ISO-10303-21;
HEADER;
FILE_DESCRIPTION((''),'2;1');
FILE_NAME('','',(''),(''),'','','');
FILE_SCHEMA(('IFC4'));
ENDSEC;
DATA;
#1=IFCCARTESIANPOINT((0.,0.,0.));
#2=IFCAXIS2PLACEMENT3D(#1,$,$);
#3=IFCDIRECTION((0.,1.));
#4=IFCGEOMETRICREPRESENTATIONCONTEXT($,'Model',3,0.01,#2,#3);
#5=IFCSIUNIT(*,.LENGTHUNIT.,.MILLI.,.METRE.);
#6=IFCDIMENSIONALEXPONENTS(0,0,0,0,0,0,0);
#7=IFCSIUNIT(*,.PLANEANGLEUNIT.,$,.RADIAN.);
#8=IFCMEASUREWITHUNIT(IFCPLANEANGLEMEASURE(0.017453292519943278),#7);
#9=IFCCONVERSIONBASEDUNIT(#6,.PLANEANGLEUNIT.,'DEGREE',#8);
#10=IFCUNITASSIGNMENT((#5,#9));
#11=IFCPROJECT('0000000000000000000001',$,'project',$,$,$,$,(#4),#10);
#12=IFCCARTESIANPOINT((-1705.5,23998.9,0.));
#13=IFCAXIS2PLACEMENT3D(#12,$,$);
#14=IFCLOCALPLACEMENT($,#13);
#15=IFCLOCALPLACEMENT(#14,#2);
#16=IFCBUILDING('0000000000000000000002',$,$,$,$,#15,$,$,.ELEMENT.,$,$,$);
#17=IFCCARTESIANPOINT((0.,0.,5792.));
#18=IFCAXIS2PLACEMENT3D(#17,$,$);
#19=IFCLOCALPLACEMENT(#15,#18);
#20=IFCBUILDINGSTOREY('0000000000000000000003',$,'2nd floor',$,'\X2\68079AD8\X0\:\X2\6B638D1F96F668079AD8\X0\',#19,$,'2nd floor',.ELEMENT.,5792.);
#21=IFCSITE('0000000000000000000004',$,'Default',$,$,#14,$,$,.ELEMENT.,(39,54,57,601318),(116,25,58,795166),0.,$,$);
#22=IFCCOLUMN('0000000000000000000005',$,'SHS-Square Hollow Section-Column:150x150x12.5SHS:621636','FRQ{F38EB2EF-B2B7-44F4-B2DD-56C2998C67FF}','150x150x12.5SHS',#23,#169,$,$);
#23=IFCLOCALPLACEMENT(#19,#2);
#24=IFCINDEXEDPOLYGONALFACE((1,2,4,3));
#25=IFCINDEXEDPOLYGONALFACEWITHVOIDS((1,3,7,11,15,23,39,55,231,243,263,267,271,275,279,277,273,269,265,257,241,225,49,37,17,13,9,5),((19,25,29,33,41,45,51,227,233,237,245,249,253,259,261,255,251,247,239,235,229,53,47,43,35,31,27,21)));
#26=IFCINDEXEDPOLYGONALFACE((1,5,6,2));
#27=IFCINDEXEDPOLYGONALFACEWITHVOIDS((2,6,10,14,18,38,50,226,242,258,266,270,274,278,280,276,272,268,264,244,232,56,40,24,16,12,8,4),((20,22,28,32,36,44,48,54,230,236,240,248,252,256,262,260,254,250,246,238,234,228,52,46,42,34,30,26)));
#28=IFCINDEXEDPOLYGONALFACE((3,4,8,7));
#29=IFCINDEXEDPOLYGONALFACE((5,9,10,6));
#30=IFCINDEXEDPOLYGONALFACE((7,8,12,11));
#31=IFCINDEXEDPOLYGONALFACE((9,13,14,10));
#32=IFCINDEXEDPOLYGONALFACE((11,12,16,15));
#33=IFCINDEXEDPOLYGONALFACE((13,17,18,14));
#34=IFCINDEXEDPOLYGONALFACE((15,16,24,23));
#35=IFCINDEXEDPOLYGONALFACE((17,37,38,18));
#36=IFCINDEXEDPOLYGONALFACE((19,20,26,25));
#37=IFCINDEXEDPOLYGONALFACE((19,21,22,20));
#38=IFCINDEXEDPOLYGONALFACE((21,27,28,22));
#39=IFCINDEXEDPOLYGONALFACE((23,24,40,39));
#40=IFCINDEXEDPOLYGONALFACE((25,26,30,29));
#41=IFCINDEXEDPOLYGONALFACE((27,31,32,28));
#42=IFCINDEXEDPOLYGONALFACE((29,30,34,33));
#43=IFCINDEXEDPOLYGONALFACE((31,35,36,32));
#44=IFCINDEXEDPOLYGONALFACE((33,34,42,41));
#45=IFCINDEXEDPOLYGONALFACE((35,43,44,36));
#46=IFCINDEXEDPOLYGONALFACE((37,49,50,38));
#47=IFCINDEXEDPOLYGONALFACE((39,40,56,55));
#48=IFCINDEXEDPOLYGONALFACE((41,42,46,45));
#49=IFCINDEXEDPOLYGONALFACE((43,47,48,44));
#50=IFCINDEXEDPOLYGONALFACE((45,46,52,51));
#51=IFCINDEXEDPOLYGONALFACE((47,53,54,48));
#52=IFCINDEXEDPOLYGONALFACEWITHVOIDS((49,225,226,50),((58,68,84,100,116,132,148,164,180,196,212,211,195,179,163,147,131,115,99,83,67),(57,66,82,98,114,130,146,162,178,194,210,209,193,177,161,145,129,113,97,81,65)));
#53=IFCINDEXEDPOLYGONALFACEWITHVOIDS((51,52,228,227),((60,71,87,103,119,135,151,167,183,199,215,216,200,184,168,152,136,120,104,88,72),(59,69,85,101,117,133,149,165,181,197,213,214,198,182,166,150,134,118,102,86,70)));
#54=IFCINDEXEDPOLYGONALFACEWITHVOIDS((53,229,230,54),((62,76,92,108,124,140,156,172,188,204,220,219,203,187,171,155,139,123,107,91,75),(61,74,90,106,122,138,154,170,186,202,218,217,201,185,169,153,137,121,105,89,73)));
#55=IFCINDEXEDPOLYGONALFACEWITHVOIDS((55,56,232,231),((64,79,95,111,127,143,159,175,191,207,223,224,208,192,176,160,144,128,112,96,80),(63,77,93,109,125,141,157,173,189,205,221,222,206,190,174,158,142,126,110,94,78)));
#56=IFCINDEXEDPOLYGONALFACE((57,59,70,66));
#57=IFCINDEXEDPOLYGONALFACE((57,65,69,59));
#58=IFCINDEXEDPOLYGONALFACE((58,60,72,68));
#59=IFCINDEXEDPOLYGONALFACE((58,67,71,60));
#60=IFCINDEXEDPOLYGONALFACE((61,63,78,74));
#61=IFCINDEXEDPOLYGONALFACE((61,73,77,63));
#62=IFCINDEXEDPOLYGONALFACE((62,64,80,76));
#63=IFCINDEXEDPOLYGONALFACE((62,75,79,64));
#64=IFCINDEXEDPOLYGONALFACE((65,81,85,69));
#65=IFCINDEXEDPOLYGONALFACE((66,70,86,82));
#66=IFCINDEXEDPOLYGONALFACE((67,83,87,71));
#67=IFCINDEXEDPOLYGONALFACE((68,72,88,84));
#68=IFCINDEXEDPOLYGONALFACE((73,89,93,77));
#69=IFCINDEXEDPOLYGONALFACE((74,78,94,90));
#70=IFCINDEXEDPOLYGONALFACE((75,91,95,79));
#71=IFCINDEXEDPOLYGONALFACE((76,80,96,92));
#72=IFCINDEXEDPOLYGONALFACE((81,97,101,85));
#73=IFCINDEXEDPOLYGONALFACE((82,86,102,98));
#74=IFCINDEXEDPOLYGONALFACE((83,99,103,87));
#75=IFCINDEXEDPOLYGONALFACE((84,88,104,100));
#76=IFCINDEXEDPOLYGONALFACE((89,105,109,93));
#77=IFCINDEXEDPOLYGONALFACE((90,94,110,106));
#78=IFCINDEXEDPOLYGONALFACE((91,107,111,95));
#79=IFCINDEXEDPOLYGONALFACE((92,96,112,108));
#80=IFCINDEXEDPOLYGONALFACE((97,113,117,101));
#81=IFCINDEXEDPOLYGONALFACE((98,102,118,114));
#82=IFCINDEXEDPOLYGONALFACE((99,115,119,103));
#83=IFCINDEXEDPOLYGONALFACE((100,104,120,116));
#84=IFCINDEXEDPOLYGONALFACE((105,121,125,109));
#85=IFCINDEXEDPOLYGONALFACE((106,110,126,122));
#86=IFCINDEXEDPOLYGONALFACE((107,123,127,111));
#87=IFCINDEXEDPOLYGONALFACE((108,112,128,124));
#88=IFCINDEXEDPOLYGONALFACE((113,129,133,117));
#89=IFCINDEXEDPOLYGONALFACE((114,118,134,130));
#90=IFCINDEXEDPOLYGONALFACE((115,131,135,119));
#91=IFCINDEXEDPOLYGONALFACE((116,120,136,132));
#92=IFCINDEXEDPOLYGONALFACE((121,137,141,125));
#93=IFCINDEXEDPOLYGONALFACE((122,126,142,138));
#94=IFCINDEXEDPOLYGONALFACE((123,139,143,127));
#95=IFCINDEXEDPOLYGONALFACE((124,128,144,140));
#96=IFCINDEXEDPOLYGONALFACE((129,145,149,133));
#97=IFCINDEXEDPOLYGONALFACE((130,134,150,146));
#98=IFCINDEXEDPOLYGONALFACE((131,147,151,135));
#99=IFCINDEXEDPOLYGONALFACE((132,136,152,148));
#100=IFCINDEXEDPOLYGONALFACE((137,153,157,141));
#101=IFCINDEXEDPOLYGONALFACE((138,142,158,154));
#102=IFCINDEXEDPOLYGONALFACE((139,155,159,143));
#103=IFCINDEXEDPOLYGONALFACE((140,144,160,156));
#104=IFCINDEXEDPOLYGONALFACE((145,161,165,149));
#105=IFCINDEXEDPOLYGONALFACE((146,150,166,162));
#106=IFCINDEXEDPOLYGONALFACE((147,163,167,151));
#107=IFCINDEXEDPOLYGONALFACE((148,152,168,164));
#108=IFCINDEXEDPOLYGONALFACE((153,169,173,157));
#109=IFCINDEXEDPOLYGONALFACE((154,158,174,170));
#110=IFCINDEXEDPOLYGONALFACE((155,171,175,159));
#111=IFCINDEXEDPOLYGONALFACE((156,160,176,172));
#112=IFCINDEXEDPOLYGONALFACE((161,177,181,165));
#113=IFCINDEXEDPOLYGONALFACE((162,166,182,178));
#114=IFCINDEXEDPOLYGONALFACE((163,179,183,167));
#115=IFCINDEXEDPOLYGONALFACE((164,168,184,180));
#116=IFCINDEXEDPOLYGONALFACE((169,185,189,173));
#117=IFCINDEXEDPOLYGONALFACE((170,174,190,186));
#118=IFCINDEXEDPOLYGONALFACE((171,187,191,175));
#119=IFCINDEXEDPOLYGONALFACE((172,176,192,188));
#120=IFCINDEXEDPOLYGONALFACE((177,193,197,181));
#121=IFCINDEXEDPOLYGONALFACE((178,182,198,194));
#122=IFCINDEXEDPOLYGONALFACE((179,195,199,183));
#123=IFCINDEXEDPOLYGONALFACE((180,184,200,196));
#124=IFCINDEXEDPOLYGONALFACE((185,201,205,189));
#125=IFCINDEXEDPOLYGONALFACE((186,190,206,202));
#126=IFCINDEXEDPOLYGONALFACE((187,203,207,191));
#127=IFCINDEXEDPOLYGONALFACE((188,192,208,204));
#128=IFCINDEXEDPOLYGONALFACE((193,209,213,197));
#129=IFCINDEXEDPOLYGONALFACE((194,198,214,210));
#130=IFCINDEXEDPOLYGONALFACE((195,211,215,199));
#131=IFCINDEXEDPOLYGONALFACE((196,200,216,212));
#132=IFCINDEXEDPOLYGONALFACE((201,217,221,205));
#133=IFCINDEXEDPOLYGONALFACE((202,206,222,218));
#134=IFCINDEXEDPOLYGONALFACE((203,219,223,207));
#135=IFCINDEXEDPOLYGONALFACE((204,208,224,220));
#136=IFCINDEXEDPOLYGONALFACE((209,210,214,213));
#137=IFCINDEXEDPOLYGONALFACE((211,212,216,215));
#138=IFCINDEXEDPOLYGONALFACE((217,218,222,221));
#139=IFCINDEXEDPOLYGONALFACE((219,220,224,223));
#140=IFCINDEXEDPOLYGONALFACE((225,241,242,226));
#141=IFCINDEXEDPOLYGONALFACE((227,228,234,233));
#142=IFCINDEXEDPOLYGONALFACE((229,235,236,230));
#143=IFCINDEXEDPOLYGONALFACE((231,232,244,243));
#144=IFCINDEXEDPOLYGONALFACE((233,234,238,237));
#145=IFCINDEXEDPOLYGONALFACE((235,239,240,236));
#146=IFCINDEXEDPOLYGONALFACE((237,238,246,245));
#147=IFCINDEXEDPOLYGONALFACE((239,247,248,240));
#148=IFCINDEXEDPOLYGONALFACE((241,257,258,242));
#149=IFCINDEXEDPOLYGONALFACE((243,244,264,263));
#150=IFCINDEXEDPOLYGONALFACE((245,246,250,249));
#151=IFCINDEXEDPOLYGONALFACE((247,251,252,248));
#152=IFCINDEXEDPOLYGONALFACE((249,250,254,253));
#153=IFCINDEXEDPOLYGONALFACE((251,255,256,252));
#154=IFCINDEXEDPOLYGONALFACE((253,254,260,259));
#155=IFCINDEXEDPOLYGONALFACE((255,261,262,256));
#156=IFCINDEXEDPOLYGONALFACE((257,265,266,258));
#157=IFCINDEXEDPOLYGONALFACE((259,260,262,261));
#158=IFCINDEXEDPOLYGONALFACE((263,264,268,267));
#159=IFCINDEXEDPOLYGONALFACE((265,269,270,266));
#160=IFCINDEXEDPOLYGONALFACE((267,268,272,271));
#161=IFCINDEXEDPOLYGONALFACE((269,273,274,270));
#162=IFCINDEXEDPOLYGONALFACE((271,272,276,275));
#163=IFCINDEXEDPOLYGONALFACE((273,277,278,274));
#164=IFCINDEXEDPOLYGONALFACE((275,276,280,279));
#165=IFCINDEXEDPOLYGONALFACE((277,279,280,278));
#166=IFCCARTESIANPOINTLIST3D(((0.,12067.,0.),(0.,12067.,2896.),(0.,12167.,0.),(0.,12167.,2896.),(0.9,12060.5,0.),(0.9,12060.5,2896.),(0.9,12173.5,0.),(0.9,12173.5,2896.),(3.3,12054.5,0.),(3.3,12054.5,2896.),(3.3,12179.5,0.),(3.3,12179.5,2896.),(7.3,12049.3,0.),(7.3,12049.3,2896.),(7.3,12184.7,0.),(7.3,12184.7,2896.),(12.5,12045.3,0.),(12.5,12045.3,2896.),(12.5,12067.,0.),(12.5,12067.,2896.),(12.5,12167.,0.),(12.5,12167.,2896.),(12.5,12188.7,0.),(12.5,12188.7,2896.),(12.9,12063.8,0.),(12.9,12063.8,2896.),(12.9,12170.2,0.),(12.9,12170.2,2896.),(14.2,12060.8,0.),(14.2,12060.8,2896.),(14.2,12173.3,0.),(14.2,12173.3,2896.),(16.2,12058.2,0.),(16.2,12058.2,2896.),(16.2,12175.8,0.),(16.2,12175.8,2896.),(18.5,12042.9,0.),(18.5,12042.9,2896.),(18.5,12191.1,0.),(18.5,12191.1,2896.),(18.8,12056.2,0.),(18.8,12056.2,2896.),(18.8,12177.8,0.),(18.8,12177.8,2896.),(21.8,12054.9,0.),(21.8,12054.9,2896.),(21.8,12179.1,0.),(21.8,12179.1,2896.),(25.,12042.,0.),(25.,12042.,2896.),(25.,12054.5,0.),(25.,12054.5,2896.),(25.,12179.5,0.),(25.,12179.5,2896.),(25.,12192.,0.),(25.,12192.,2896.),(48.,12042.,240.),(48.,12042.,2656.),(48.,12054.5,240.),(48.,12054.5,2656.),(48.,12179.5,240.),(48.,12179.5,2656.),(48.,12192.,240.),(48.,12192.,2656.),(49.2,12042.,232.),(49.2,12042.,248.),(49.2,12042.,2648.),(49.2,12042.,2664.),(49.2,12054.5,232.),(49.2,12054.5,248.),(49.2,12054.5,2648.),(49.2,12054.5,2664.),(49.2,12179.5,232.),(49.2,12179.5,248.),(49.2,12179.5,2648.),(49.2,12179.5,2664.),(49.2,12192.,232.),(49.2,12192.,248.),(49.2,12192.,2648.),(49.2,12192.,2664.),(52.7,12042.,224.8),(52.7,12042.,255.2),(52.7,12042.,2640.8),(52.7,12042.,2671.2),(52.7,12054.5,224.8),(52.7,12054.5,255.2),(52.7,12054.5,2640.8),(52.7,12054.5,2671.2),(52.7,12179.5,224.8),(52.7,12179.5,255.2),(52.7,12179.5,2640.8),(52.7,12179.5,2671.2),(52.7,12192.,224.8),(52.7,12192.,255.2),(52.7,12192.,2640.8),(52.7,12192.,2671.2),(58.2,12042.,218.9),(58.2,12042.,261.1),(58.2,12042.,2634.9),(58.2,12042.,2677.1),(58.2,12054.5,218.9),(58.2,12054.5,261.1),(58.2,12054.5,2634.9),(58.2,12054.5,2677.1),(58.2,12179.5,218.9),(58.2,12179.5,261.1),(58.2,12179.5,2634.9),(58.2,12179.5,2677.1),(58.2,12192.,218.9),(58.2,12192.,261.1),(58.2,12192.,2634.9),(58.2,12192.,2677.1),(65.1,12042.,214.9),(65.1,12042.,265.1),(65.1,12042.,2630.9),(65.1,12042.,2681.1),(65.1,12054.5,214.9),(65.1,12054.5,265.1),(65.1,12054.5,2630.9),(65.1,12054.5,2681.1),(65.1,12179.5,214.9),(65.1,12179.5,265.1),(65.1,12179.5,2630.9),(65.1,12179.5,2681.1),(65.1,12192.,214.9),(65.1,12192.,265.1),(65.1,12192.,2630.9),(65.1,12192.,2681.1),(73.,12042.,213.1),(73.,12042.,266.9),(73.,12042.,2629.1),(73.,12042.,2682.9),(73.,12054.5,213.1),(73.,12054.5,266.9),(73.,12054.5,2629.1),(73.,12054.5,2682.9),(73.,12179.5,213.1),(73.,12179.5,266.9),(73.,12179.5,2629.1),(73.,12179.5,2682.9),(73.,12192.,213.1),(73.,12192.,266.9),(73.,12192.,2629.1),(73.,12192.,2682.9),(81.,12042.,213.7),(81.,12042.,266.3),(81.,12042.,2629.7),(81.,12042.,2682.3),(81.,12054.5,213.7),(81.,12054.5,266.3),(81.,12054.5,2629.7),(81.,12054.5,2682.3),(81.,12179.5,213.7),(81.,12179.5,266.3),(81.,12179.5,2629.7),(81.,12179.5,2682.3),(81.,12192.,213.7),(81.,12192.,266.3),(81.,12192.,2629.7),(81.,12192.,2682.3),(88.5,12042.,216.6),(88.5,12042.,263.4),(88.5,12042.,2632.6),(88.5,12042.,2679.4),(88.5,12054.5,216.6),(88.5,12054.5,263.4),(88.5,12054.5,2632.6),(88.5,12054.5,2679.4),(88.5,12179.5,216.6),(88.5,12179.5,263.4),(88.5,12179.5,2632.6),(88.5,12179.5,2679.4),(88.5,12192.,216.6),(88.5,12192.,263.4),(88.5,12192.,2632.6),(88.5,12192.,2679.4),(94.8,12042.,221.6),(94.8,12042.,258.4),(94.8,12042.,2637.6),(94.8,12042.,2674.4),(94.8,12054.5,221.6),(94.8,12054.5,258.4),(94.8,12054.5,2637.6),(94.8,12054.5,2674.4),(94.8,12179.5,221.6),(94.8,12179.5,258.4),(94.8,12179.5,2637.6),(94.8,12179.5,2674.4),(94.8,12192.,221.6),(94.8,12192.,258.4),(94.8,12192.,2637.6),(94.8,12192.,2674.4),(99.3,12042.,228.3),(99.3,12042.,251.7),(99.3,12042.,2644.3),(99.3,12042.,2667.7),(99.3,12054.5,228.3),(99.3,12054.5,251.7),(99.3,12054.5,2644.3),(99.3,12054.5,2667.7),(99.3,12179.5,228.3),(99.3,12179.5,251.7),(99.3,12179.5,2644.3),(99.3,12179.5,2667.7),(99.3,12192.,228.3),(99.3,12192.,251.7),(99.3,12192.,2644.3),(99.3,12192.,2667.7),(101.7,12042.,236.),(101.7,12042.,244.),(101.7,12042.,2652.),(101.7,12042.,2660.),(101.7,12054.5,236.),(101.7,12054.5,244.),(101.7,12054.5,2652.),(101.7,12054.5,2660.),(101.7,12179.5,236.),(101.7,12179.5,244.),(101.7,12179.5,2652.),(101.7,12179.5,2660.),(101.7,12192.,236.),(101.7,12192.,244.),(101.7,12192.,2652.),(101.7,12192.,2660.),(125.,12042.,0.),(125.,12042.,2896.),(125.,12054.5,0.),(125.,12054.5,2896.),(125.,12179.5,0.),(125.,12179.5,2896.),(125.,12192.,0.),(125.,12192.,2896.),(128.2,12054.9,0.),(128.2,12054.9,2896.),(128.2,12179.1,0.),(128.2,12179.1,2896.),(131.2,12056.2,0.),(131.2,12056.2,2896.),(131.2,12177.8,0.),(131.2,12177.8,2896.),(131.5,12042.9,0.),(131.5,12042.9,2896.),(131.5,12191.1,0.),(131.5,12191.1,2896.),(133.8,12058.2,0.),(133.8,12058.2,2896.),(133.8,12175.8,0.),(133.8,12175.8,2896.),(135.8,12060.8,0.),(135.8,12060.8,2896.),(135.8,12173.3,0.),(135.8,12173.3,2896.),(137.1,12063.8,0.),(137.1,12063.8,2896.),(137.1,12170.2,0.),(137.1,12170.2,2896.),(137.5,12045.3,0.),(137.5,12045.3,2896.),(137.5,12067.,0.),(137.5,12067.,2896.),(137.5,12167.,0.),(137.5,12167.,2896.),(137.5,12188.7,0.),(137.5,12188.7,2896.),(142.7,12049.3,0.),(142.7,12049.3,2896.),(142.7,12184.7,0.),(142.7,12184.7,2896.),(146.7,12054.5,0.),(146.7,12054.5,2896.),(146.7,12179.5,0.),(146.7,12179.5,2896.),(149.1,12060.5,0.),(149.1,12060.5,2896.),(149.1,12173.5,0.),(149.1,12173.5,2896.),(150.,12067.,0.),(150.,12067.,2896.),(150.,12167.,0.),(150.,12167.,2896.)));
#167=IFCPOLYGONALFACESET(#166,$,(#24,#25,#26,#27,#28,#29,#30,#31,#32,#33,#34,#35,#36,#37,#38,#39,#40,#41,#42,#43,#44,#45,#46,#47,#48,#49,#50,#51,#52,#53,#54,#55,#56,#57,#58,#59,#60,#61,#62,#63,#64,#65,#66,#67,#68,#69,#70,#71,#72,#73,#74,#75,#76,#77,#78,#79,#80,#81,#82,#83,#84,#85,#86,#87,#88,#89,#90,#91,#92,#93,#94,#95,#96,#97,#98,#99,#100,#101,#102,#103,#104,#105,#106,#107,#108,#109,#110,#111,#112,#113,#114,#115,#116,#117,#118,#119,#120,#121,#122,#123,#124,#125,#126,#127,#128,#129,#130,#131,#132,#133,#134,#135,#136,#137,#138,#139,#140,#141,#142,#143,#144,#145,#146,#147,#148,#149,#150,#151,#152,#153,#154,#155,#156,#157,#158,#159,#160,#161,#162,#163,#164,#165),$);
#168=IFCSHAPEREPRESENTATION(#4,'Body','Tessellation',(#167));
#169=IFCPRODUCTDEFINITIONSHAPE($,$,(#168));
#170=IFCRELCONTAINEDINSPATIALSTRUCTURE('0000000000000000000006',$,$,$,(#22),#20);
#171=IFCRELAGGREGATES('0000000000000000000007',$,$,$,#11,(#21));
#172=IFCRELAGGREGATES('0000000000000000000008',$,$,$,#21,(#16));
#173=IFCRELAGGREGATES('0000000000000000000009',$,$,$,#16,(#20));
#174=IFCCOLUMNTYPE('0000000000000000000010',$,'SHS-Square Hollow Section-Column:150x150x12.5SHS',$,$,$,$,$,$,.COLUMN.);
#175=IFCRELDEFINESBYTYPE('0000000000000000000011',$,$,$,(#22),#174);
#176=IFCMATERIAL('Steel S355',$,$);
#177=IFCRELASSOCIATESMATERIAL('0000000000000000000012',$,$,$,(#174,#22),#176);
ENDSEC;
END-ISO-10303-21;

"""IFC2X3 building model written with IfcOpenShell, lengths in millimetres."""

from ifc_helpers import new_model, entity, si_unit, converted_unit, direction, frame, frame_2d, origin, origin_2d, place, context, project, spatial, circle_curve, hollow_rectangle, outline, extrude, material, type_object, element, save


model = new_model("IFC2X3")

# Units and contexts
model_context = context("Model", 3, precision=0.01, world=origin(), true_north=direction((0.0, 1.0)))
ifc_project = project(units=[si_unit("LENGTHUNIT", "METRE", prefix="MILLI"), converted_unit("PLANEANGLEUNIT", "DEGREE", entity("IfcPlaneAngleMeasure", 0.017453292519943278), si_unit("PLANEANGLEUNIT", "RADIAN"), dimensions=[0, 0, 0, 0, 0, 0, 0])], contexts=[model_context])

# Site, building, storey
site_placement = place(None, frame((-1705.5, 23998.9, 0.0)))
site = spatial("IfcSite", under=ifc_project, at=site_placement, Name="Default", CompositionType="ELEMENT", RefLatitude=(39, 54, 57, 601318), RefLongitude=(116, 25, 58, 795166), RefElevation=0.0)
building_placement = place(site_placement, origin())
building = spatial("IfcBuilding", under=site, at=building_placement, CompositionType="ELEMENT")
storey_placement = place(building_placement, frame((0.0, 0.0, 5792.0)))
storey = spatial("IfcBuildingStorey", under=building, at=storey_placement, Name="2nd floor", ObjectType="标高:正负零标高", LongName="2nd floor", CompositionType="ELEMENT", Elevation=5792.0)

# Column, openings
ifc_material_1 = material(Name="Steel S355")
column_type_1 = type_object("IfcColumnType", Name="SHS-Square Hollow Section-Column:150x150x12.5SHS", PredefinedType="COLUMN", material=ifc_material_1)
column_1_placement = place(storey_placement, frame((75.0, 12117.0, 2896.0), z_axis=(0.0, 0.0, 1.0), x_axis=(0.0, -1.0, 0.0)))
column_1 = element("IfcColumn", 1, at=column_1_placement, inside=storey, type_object=column_type_1, material=ifc_material_1, Name="SHS-Square Hollow Section-Column:150x150x12.5SHS:621636", Description="FRQ{F38EB2EF-B2B7-44F4-B2DD-56C2998C67FF}", ObjectType="150x150x12.5SHS", context=model_context, shape_type="SweptSolid", body=[
    extrude(hollow_rectangle(XDim=150.0, YDim=150.0, WallThickness=12.5, InnerFilletRadius=12.5, OuterFilletRadius=25.0, at=origin_2d()), origin(), (0.0, 0.0, -1.0), 2896.0),
])
opening_1_placement = place(column_1_placement, frame((175.1, 0.0, -2896.0), z_axis=(-1.0, 0.0, 0.0), x_axis=(0.0, -1.0, 0.0)))
element("IfcOpeningElement", 2, at=opening_1_placement, cuts=column_1, ObjectType="Opening", context=model_context, shape_type="SweptSolid", body=[
    extrude(outline(circle_curve(frame_2d((0.0, 240.0), x_axis=(1.0, 0.0)), 27.0)), origin(), (0.0, 0.0, 1.0), 350.2),
])
opening_2_placement = place(column_1_placement, frame((175.1, 0.0, 0.0), z_axis=(-1.0, 0.0, 0.0), x_axis=(0.0, -1.0, 0.0)))
element("IfcOpeningElement", 3, at=opening_2_placement, cuts=column_1, ObjectType="Opening", context=model_context, shape_type="SweptSolid", body=[
    extrude(outline(circle_curve(frame_2d((0.0, -240.0), x_axis=(1.0, 0.0)), 27.0)), origin(), (0.0, 0.0, 1.0), 350.2),
])

save(model, "model.ifc")
